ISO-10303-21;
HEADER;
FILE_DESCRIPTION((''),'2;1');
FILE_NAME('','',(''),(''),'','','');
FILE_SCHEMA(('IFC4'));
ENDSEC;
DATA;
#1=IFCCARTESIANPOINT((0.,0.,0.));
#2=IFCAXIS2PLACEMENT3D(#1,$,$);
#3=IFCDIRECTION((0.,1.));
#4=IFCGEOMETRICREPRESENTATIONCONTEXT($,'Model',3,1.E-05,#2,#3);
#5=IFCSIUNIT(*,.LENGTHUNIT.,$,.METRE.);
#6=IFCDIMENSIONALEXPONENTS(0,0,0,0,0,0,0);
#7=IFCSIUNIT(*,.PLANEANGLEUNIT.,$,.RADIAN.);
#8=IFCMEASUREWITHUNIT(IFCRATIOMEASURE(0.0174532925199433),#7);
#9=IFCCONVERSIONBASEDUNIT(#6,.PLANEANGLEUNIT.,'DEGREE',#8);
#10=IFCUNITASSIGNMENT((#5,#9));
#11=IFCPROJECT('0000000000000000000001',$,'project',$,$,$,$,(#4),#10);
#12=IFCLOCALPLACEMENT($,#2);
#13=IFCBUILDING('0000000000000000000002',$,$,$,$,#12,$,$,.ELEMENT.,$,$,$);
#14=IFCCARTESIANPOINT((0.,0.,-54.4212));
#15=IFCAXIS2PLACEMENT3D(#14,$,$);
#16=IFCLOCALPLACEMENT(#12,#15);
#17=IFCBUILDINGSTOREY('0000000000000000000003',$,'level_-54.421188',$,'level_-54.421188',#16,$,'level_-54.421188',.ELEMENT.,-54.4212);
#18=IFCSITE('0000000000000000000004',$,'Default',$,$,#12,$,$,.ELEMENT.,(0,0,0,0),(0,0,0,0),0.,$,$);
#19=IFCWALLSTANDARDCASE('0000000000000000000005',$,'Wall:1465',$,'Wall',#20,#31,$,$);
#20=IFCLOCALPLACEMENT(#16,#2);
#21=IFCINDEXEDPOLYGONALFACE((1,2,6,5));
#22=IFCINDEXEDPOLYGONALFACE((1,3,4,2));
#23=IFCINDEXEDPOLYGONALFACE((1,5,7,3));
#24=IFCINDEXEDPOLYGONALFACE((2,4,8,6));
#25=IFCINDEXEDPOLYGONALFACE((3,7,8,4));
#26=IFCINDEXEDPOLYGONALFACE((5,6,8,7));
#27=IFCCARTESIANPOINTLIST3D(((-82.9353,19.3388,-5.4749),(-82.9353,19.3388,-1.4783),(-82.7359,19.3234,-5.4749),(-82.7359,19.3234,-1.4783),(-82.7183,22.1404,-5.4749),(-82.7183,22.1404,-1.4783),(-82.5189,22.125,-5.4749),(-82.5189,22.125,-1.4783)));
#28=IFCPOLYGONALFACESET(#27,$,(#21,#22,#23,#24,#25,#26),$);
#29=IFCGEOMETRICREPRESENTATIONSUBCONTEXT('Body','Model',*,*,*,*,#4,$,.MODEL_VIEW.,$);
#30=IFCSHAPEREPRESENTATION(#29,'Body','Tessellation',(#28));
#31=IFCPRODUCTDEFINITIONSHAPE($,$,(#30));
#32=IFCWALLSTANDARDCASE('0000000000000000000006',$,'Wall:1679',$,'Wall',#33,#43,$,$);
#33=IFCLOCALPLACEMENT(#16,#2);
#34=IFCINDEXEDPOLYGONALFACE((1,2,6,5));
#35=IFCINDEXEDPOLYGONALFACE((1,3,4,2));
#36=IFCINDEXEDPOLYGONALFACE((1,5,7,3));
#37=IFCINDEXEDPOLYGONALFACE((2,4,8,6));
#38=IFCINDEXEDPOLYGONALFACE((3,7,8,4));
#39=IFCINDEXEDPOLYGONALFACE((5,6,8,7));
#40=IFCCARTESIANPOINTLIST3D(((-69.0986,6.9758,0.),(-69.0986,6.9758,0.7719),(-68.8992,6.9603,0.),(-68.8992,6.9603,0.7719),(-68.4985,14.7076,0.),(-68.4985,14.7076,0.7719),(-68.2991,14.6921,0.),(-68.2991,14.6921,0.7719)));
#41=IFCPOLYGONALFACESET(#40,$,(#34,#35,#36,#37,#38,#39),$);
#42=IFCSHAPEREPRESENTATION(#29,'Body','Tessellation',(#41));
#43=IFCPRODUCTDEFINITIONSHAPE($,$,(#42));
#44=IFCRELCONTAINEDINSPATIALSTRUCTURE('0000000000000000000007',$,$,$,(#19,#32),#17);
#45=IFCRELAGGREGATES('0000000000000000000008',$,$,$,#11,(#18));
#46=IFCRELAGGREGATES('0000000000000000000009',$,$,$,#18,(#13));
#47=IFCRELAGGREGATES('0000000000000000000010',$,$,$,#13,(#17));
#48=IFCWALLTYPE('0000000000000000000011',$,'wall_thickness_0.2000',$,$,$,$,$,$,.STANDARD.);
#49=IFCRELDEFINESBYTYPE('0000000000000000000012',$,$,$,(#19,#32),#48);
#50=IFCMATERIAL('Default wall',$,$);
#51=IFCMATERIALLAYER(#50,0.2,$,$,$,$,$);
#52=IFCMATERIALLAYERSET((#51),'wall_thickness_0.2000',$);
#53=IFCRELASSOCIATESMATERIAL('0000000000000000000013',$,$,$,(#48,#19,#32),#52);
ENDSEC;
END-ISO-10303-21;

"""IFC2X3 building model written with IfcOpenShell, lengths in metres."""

from ifc_helpers import new_model, entity, si_unit, converted_unit, direction, frame, origin, place, context, subcontext, project, spatial, polyline, outline, extrude, material, layer, layer_set, layer_usage, type_object, element, save


model = new_model("IFC2X3")

# Units and contexts
model_context = context("Model", 3, precision=1e-05, world=origin(), true_north=direction((0.0, 1.0)))
body_context = subcontext(model_context, "Body", "Model", "MODEL_VIEW")
ifc_project = project(units=[si_unit("LENGTHUNIT", "METRE"), converted_unit("PLANEANGLEUNIT", "DEGREE", entity("IfcRatioMeasure", 0.0174532925199433), si_unit("PLANEANGLEUNIT", "RADIAN"), dimensions=[0, 0, 0, 0, 0, 0, 0])], contexts=[model_context])

# Site, building, storey
placement_1 = place(None, origin())
site = spatial("IfcSite", under=ifc_project, at=placement_1, Name="Default", CompositionType="ELEMENT", RefLatitude=(0, 0, 0, 0), RefLongitude=(0, 0, 0, 0), RefElevation=0.0)
building = spatial("IfcBuilding", under=site, at=placement_1, CompositionType="ELEMENT")
storey_placement = place(placement_1, frame((0.0, 0.0, -54.4212)))
storey = spatial("IfcBuildingStorey", under=building, at=storey_placement, Name="level_-54.421188", ObjectType="level_-54.421188", LongName="level_-54.421188", CompositionType="ELEMENT", Elevation=-54.4212)

# Shared definitions
ifc_material_1 = material(Name="Default wall")
ifc_layer = layer(ifc_material_1, 0.2)
ifc_layer_set = layer_set([ifc_layer], Name="wall_thickness_0.2000")
ifc_layer_usage = layer_usage(ifc_layer_set, "AXIS2", "POSITIVE", -0.1)
wall_type = type_object("IfcWallType", Name="wall_thickness_0.2000", PredefinedType="STANDARD", material=ifc_layer_set)

# Walls
placement_2 = place(placement_1, frame((0.0, 0.0, -59.8961)))
wall_1_placement = place(placement_2, frame((-82.6186, 22.1327, 0.0), z_axis=(0.0, 0.0, 1.0), x_axis=(-0.077242, -0.997012, 0.0)))
element("IfcWallStandardCase", 1, at=wall_1_placement, inside=storey, type_object=wall_type, material=ifc_layer_usage, Name="Wall:1465", ObjectType="Wall", context=body_context, shape_type="SweptSolid", body=[
    extrude(outline(polyline([(2.81, -0.1), (2.81, 0.1), (0.0, 0.1), (0.0, -0.1), (2.81, -0.1)])), origin(), (0.0, 0.0, 1.0), 3.9965),
])
wall_2_placement = place(storey_placement, frame((-68.9989, 6.968, 0.0), z_axis=(0.0, 0.0, 1.0), x_axis=(0.077384, 0.997001, 0.0)))
element("IfcWallStandardCase", 2, at=wall_2_placement, inside=storey, type_object=wall_type, material=ifc_layer_usage, Name="Wall:1679", ObjectType="Wall", context=body_context, shape_type="SweptSolid", body=[
    extrude(outline(polyline([(7.7551, -0.1), (7.7551, 0.1), (0.0, 0.1), (0.0, -0.1), (7.7551, -0.1)])), origin(), (0.0, 0.0, 1.0), 0.7719),
])

save(model, "model.ifc")
